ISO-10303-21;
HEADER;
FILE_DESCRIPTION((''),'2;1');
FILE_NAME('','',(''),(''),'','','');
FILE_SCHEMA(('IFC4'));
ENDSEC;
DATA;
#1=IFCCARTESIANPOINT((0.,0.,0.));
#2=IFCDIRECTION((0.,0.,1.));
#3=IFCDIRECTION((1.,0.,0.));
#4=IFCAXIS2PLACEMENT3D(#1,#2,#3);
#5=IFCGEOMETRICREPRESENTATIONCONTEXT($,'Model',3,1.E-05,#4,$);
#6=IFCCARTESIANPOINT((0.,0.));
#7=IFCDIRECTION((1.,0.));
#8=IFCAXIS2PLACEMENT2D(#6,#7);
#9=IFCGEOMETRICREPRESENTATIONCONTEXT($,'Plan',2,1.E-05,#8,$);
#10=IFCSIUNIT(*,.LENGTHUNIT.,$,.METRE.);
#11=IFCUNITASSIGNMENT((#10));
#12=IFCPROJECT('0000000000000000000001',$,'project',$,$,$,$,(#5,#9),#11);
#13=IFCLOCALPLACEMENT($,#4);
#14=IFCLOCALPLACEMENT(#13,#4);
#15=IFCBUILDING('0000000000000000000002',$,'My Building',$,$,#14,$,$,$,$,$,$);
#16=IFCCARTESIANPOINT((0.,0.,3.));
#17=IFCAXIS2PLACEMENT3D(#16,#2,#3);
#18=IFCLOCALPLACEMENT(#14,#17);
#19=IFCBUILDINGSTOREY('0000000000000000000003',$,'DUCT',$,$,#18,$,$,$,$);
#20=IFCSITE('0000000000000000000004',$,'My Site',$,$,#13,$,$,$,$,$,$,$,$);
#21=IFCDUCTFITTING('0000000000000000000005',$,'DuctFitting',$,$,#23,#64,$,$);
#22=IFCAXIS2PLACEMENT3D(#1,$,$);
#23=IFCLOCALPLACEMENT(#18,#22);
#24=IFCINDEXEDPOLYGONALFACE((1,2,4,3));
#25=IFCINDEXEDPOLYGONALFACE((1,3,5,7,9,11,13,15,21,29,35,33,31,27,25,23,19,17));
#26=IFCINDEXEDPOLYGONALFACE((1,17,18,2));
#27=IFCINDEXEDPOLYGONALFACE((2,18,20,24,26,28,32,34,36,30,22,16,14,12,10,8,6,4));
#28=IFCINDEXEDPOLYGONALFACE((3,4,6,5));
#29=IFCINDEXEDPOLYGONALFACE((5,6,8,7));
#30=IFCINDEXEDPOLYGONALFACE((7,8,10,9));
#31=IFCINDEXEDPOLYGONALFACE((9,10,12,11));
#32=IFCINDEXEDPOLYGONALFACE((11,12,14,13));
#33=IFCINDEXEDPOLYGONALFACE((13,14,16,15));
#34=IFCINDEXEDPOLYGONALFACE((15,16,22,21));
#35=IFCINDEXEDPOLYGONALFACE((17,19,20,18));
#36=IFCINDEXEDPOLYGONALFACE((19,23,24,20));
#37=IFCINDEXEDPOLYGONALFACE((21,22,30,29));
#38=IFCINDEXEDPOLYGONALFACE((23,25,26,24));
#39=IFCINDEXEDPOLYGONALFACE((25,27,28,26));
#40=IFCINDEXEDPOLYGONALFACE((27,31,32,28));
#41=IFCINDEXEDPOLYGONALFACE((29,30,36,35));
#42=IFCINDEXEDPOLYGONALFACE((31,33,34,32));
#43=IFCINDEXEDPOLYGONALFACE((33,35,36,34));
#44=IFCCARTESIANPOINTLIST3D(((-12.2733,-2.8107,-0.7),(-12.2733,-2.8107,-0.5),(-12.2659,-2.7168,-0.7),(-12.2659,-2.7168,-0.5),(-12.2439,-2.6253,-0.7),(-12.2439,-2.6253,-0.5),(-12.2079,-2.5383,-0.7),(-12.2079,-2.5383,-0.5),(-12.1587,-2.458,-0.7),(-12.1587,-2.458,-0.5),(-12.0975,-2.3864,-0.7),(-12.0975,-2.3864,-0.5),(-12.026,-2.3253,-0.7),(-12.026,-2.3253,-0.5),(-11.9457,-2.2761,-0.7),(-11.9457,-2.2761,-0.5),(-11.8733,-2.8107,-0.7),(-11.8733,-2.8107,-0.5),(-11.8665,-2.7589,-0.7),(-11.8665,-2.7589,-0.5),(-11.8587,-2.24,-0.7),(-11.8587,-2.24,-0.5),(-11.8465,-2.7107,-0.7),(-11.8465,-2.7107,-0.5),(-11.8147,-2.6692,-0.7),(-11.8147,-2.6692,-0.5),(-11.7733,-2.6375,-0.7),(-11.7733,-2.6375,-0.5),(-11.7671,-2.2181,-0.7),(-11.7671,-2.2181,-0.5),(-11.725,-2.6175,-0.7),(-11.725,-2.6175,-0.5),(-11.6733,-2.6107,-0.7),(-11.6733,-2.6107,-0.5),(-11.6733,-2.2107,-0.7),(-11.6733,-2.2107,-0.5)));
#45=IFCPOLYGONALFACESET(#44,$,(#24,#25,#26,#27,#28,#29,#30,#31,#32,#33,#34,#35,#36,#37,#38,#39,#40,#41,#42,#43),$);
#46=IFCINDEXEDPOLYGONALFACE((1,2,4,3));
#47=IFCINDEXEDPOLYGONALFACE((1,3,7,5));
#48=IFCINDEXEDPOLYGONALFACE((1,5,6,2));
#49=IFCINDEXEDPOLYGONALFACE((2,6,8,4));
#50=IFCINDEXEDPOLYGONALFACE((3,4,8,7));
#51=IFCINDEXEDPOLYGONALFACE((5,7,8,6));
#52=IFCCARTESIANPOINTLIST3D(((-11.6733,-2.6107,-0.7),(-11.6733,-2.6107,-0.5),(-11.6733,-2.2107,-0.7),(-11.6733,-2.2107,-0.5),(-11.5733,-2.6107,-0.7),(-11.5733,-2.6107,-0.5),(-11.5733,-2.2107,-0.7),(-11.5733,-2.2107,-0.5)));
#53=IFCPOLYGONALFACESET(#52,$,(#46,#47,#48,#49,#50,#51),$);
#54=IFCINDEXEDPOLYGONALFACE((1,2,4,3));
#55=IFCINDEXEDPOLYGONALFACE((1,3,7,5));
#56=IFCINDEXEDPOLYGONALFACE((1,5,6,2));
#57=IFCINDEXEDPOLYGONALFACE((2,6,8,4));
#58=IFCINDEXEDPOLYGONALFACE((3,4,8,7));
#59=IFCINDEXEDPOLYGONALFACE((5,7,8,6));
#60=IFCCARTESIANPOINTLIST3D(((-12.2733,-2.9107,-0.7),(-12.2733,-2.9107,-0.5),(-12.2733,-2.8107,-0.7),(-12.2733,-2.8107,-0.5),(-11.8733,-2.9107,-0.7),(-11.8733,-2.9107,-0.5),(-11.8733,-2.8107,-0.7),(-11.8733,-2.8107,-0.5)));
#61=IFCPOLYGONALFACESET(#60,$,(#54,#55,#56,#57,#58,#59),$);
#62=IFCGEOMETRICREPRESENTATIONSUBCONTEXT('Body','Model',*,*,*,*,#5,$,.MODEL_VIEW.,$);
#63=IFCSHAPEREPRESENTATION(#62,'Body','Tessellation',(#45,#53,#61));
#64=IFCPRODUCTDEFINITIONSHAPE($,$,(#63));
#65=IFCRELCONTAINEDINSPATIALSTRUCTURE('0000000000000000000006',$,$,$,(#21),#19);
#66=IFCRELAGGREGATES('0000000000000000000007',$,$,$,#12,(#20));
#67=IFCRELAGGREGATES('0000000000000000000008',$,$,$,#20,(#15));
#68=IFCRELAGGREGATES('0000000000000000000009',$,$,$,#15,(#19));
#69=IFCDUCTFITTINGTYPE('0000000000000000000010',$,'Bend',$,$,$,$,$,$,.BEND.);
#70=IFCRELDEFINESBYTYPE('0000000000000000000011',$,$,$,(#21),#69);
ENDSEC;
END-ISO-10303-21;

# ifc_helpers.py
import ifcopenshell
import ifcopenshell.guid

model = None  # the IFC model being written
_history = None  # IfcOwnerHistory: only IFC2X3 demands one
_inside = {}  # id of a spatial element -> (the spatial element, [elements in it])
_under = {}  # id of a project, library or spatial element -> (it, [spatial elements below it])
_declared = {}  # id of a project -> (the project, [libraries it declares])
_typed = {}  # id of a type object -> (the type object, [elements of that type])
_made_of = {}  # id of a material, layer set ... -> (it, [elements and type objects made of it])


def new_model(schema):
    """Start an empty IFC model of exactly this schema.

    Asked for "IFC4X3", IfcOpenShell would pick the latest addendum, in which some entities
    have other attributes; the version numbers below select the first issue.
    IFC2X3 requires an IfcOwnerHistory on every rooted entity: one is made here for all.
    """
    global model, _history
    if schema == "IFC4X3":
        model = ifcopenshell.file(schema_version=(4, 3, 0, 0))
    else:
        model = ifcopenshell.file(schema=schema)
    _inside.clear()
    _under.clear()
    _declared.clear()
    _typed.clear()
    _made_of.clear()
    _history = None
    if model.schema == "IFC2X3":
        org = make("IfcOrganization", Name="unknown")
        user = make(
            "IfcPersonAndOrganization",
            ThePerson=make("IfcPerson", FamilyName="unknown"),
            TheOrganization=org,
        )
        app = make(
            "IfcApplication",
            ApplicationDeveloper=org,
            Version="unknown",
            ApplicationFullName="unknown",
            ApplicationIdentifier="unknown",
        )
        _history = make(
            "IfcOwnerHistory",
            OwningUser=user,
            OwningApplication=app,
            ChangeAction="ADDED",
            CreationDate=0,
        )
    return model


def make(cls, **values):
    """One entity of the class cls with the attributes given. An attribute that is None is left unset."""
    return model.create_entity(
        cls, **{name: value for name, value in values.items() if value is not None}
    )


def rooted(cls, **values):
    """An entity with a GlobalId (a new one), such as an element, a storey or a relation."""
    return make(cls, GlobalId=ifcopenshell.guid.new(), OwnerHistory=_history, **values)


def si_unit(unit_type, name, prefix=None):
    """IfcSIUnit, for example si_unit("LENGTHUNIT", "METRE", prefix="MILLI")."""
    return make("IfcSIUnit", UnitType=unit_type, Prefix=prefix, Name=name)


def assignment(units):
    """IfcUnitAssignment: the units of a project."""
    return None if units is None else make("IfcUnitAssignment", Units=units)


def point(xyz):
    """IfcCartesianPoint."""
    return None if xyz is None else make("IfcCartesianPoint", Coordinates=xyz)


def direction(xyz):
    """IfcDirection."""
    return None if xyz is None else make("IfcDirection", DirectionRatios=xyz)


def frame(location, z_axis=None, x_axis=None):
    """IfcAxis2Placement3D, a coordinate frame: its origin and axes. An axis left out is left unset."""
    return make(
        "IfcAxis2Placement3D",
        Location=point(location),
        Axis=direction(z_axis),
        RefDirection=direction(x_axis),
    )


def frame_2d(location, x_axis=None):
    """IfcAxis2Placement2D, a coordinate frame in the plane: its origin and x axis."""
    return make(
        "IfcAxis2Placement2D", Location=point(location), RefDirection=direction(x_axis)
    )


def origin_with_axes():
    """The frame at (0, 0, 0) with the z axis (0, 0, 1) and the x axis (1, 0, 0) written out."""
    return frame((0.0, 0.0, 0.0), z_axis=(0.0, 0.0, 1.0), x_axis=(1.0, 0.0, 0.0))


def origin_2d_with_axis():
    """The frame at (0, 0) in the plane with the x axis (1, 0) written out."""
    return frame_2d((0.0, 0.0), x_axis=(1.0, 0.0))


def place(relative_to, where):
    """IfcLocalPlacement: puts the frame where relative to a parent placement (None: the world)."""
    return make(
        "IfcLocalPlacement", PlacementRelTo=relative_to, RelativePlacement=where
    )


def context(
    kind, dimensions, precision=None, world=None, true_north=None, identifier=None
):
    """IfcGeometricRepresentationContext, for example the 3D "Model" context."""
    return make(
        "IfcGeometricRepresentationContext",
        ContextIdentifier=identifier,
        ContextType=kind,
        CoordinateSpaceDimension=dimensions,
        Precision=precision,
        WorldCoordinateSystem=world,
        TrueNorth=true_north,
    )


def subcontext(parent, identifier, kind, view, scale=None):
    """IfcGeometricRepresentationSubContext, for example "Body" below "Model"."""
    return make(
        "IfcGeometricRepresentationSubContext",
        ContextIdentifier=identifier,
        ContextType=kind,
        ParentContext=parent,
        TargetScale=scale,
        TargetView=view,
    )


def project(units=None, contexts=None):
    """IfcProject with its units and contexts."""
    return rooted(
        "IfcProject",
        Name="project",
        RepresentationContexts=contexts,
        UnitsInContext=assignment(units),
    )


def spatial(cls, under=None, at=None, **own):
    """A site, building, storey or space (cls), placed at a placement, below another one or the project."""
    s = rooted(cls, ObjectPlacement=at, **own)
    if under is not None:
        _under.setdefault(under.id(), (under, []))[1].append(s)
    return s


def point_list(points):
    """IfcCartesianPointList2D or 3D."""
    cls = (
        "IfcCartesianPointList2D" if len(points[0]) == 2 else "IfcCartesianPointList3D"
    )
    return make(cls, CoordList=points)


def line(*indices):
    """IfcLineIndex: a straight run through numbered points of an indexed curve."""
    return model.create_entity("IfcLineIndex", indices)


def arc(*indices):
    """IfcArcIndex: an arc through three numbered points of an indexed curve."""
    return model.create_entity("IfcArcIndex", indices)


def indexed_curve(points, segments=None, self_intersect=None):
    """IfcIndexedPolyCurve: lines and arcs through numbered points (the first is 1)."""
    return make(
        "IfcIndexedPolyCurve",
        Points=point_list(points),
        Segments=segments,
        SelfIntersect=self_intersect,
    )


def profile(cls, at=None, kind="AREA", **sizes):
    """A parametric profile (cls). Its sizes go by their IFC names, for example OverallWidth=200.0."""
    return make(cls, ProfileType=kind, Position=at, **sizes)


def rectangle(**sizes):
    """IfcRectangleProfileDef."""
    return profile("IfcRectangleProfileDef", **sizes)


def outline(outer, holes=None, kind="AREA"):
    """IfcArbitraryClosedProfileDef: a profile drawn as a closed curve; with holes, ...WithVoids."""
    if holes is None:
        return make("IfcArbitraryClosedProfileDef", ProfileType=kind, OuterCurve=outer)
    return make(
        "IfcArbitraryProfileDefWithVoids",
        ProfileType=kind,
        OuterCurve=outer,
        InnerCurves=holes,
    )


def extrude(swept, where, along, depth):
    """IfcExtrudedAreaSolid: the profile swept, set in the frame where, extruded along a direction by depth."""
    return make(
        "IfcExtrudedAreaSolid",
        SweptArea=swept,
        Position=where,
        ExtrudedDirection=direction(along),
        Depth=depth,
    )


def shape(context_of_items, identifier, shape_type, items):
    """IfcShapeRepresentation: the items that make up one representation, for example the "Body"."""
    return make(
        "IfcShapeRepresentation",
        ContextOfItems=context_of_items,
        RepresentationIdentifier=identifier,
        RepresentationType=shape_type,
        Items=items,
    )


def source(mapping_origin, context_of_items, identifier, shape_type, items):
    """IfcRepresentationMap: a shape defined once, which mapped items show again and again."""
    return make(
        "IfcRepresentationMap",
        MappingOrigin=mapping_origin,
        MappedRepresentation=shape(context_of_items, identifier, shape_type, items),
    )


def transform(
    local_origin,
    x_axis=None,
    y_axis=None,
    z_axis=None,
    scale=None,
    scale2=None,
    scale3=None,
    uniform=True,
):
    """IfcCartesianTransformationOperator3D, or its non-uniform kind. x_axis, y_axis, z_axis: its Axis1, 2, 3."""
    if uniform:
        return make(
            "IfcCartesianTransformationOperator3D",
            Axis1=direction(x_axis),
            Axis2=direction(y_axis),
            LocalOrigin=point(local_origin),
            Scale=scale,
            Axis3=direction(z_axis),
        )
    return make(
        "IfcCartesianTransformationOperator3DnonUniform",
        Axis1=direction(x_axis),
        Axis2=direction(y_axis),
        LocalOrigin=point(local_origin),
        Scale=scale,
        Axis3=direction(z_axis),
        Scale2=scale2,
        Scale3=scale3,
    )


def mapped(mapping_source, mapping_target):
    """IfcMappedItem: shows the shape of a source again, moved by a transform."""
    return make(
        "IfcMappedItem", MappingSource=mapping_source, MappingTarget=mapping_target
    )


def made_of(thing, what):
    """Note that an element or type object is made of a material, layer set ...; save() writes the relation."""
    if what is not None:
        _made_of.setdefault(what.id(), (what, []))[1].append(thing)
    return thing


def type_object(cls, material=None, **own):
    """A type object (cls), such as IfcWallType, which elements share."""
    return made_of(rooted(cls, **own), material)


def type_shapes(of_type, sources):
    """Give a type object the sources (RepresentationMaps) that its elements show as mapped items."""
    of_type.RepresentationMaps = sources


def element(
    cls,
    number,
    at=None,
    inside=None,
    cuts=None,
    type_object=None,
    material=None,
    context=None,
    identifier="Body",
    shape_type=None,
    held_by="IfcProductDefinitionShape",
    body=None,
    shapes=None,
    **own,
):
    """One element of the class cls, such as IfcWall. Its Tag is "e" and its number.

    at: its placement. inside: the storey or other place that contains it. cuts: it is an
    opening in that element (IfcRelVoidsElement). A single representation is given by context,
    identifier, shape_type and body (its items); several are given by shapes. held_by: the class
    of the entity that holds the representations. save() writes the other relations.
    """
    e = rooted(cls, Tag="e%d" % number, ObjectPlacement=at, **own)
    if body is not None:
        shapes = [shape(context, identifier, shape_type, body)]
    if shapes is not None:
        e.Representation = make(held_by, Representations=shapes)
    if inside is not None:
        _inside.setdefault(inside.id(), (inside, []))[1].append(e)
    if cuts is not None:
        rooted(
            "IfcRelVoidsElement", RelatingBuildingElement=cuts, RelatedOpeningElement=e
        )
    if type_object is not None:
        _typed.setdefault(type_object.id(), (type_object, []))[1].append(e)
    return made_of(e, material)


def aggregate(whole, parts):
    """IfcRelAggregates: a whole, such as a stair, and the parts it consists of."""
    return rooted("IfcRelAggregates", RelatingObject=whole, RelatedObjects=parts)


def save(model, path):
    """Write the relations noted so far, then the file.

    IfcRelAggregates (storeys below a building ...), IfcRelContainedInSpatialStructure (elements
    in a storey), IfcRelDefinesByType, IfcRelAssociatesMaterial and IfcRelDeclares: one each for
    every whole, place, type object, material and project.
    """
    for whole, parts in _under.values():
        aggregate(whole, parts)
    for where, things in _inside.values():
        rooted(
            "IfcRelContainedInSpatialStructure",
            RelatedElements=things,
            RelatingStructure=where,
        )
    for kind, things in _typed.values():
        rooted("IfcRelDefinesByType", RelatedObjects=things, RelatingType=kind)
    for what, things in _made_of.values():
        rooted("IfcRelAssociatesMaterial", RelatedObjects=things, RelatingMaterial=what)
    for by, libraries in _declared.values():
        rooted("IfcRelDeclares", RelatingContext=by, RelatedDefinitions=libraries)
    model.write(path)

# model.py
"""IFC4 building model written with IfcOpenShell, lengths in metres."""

from ifc_helpers import new_model, si_unit, frame, origin_with_axes, origin_2d_with_axis, place, context, subcontext, project, spatial, line, arc, indexed_curve, rectangle, outline, extrude, source, transform, mapped, type_object, type_shapes, element, save


model = new_model("IFC4")

# Units and contexts
model_context = context("Model", 3, precision=1e-05, world=origin_with_axes())
plan_context = context("Plan", 2, precision=1e-05, world=origin_2d_with_axis())
body_context = subcontext(model_context, "Body", "Model", "MODEL_VIEW")
ifc_project = project(units=[si_unit("LENGTHUNIT", "METRE")], contexts=[model_context, plan_context])

# Site, building, storey
site_placement = place(None, origin_with_axes())
site = spatial("IfcSite", under=ifc_project, at=site_placement, Name="My Site")
building_placement = place(site_placement, origin_with_axes())
building = spatial("IfcBuilding", under=site, at=building_placement, Name="My Building")
storey_placement = place(building_placement, frame((0.0, 0.0, 3.0), z_axis=(0.0, 0.0, 1.0), x_axis=(1.0, 0.0, 0.0)))
storey = spatial("IfcBuildingStorey", under=building, at=storey_placement, Name="DUCT")

# Duct fitting
duct_fitting_type = type_object("IfcDuctFittingType", Name="Bend", PredefinedType="BEND")
shared_shape = source(origin_with_axes(), body_context, "Body", "SweptSolid", [
    extrude(outline(indexed_curve([(-0.2, 0.0), (-0.2586, -0.1414), (-0.4, -0.2), (-0.4, -0.6), (0.0243, -0.4243), (0.2, 0.0)], segments=[arc(1, 2, 3), line(3, 4), arc(4, 5, 6), line(6, 1)])), frame((0.0, -0.1, -0.1), z_axis=(0.0, -1.0, 0.0), x_axis=(1.0, 0.0, 0.0)), (0.0, 0.0, -1.0), 0.2),
    extrude(rectangle(XDim=0.4, YDim=0.2), origin_with_axes(), (0.0, 0.0, -1.0), 0.1),
    extrude(rectangle(XDim=0.4, YDim=0.2), frame((-0.4, 0.0, -0.5), z_axis=(-1.0, 0.0, 0.0), x_axis=(0.0, 0.0, -1.0)), (0.0, 0.0, 1.0), 0.1),
])
type_shapes(duct_fitting_type, [shared_shape])
for number, where, z_axis, x_axis, name in (
    (1, (-11.5733, -2.4107, -0.6), (1.0, 0.0, 0.0), (0.0, 1.0, 0.0), "DuctFitting"),
):
    element("IfcDuctFitting", number, at=place(storey_placement, frame(where, z_axis=z_axis, x_axis=x_axis)), inside=storey, type_object=duct_fitting_type, Name=name, context=body_context, shape_type="MappedRepresentation", body=[
        mapped(shared_shape, transform((0.0, 0.0, 0.0), x_axis=(1.0, 0.0, 0.0), y_axis=(0.0, 1.0, 0.0), z_axis=(0.0, 0.0, 1.0), scale=1.0)),
    ])

save(model, "model.ifc")
